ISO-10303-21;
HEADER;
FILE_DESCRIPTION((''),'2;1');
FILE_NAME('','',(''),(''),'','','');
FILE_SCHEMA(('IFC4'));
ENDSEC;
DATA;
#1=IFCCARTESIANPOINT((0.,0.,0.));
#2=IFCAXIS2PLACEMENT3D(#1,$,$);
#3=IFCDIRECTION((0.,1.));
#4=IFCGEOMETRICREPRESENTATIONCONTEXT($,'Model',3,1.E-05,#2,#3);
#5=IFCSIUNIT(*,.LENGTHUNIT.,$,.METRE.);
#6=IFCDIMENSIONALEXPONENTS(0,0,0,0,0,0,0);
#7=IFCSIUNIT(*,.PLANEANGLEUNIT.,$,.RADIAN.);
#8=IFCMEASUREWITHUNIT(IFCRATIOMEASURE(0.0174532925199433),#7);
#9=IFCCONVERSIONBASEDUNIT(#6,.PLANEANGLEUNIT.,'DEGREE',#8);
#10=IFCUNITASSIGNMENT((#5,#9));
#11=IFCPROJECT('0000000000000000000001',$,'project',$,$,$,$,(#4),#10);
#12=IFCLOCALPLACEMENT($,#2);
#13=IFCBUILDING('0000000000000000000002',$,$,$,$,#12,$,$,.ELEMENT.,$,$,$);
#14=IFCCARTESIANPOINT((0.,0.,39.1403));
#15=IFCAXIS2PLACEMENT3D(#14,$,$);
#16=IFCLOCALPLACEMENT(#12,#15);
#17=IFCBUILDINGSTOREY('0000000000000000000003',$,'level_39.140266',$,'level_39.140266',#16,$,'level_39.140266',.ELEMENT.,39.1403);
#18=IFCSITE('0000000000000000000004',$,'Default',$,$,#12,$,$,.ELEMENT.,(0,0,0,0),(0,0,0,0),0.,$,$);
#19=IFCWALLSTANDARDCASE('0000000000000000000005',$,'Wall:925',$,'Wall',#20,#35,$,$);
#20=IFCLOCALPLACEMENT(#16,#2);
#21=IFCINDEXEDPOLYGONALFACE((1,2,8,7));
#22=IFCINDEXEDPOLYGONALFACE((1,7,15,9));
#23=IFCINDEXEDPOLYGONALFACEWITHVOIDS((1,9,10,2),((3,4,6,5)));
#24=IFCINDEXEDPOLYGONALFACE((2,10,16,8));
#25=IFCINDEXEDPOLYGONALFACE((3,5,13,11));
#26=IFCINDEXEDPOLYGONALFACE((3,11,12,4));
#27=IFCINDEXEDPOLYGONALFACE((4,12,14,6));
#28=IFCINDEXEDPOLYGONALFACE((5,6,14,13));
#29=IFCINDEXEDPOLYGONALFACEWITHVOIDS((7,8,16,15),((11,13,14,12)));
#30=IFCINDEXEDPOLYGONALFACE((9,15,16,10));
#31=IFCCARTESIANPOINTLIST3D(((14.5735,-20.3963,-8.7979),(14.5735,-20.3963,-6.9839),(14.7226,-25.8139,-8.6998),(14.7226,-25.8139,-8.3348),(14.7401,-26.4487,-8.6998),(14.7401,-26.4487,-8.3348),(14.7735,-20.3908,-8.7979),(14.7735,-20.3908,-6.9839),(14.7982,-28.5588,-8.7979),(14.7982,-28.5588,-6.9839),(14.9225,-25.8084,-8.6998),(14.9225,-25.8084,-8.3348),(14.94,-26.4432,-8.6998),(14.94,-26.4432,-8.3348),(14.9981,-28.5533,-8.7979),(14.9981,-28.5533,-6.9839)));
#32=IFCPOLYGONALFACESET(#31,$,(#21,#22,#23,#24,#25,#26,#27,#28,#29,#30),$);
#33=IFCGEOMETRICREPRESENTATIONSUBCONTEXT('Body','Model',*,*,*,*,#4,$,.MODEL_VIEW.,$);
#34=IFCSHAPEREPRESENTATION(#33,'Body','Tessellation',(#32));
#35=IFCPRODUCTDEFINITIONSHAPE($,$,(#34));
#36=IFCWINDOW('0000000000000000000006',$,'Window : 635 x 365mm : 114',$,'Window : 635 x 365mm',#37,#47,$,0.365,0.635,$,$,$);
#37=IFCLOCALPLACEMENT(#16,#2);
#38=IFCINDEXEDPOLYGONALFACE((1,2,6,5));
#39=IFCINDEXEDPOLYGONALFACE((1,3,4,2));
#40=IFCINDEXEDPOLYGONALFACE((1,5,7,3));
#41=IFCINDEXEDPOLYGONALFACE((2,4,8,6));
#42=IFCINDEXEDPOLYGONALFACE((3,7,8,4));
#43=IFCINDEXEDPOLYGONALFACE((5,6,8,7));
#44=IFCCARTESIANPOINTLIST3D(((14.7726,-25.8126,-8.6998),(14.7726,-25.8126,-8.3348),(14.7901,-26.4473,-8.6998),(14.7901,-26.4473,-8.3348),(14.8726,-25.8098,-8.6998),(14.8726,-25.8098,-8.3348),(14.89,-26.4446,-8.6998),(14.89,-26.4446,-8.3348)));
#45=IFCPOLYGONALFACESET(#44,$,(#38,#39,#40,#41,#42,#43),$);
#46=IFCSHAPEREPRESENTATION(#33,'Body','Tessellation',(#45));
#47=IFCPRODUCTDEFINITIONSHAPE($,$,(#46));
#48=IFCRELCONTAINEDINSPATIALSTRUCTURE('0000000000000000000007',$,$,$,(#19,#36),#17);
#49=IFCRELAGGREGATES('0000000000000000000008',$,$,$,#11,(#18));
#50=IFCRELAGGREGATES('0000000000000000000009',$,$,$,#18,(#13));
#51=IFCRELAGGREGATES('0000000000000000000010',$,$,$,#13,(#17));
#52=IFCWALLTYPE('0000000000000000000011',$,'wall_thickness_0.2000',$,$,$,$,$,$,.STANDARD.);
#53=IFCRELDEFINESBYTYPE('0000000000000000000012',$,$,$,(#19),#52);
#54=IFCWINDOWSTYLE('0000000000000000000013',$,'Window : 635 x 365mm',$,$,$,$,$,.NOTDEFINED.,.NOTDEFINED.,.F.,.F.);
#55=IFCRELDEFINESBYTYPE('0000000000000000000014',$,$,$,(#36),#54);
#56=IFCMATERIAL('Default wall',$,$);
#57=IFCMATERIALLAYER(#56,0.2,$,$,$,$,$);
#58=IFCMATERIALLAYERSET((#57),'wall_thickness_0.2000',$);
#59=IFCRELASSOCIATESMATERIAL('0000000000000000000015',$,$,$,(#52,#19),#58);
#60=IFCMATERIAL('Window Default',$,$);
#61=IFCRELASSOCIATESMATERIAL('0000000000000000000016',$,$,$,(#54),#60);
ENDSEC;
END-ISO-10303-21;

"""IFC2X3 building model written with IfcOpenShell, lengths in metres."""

from ifc_helpers import new_model, entity, si_unit, converted_unit, direction, frame, frame_2d, origin, origin_2d_with_axis, place, context, subcontext, project, spatial, polyline, rectangle, outline, extrude, source, transform, mapped, material, layer, layer_set, layer_usage, type_object, type_shapes, element, fill, save


model = new_model("IFC2X3")

# Units and contexts
model_context = context("Model", 3, precision=1e-05, world=origin(), true_north=direction((0.0, 1.0)))
body_context = subcontext(model_context, "Body", "Model", "MODEL_VIEW")
ifc_project = project(units=[si_unit("LENGTHUNIT", "METRE"), converted_unit("PLANEANGLEUNIT", "DEGREE", entity("IfcRatioMeasure", 0.0174532925199433), si_unit("PLANEANGLEUNIT", "RADIAN"), dimensions=[0, 0, 0, 0, 0, 0, 0])], contexts=[model_context])

# Site, building, storey
placement_1 = place(None, origin())
site = spatial("IfcSite", under=ifc_project, at=placement_1, Name="Default", CompositionType="ELEMENT", RefLatitude=(0, 0, 0, 0), RefLongitude=(0, 0, 0, 0), RefElevation=0.0)
building = spatial("IfcBuilding", under=site, at=placement_1, CompositionType="ELEMENT")
storey_placement = place(placement_1, frame((0.0, 0.0, 39.1403)))
storey = spatial("IfcBuildingStorey", under=building, at=storey_placement, Name="level_39.140266", ObjectType="level_39.140266", LongName="level_39.140266", CompositionType="ELEMENT", Elevation=39.1403)

# Wall, opening, window
ifc_material_1 = material(Name="Default wall")
ifc_layer = layer(ifc_material_1, 0.2)
ifc_layer_set = layer_set([ifc_layer], Name="wall_thickness_0.2000")
ifc_layer_usage = layer_usage(ifc_layer_set, "AXIS2", "POSITIVE", -0.1)
wall_type = type_object("IfcWallType", Name="wall_thickness_0.2000", PredefinedType="STANDARD", material=ifc_layer_set)
placement_2 = place(placement_1, frame((0.0, 0.0, 30.3424)))
wall_1_placement = place(placement_2, frame((14.8981, -28.5561, 0.0), z_axis=(0.0, 0.0, 1.0), x_axis=(-0.027509, 0.999622, 0.0)))
wall_1 = element("IfcWallStandardCase", 1, at=wall_1_placement, inside=storey, type_object=wall_type, material=ifc_layer_usage, Name="Wall:925", ObjectType="Wall", context=body_context, shape_type="SweptSolid", body=[
    extrude(outline(polyline([(8.1656, -0.1), (8.1656, 0.1), (0.0, 0.1), (0.0, -0.1), (8.1656, -0.1)])), origin(), (0.0, 0.0, 1.0), 1.8141),
])
opening_1_placement = place(wall_1_placement, frame((2.1109, -0.1, 0.0982)))
opening_1 = element("IfcOpeningElement", 2, at=opening_1_placement, cuts=wall_1, ObjectType="Opening", context=body_context, shape_type="SweptSolid", body=[
    extrude(rectangle(XDim=0.635, YDim=0.365, at=frame_2d((0.1825, 0.3175), x_axis=(0.0, 1.0))), frame((0.0, 0.0, 0.0), z_axis=(0.0, 1.0, 0.0), x_axis=(0.0, 0.0, 1.0)), (0.0, 0.0, 1.0), 0.2),
])
ifc_material_2 = material(Name="Window Default")
window_style_1 = type_object("IfcWindowStyle", Name="Window : 635 x 365mm", ConstructionType="NOTDEFINED", OperationType="NOTDEFINED", ParameterTakesPrecedence=False, Sizeable=False, material=ifc_material_2)
shared_shape_1 = source(origin(), body_context, "Body", "SweptSolid", [
    extrude(rectangle(XDim=0.1, YDim=0.635, at=origin_2d_with_axis()), frame((0.3175, 0.1, 0.0), z_axis=(0.0, 0.0, 1.0), x_axis=(0.0, 1.0, 0.0)), (0.0, 0.0, 1.0), 0.365),
])
type_shapes(window_style_1, [shared_shape_1])
window_1_placement = place(opening_1_placement, origin())
window_1 = element("IfcWindow", 3, at=window_1_placement, inside=storey, type_object=window_style_1, Name="Window : 635 x 365mm : 114", ObjectType="Window : 635 x 365mm", OverallHeight=0.365, OverallWidth=0.635, context=body_context, shape_type="MappedRepresentation", body=[
    mapped(shared_shape_1, transform((0.0, 0.0, 0.0), scale=1.0)),
])
fill(opening_1, window_1)

save(model, "model.ifc")
